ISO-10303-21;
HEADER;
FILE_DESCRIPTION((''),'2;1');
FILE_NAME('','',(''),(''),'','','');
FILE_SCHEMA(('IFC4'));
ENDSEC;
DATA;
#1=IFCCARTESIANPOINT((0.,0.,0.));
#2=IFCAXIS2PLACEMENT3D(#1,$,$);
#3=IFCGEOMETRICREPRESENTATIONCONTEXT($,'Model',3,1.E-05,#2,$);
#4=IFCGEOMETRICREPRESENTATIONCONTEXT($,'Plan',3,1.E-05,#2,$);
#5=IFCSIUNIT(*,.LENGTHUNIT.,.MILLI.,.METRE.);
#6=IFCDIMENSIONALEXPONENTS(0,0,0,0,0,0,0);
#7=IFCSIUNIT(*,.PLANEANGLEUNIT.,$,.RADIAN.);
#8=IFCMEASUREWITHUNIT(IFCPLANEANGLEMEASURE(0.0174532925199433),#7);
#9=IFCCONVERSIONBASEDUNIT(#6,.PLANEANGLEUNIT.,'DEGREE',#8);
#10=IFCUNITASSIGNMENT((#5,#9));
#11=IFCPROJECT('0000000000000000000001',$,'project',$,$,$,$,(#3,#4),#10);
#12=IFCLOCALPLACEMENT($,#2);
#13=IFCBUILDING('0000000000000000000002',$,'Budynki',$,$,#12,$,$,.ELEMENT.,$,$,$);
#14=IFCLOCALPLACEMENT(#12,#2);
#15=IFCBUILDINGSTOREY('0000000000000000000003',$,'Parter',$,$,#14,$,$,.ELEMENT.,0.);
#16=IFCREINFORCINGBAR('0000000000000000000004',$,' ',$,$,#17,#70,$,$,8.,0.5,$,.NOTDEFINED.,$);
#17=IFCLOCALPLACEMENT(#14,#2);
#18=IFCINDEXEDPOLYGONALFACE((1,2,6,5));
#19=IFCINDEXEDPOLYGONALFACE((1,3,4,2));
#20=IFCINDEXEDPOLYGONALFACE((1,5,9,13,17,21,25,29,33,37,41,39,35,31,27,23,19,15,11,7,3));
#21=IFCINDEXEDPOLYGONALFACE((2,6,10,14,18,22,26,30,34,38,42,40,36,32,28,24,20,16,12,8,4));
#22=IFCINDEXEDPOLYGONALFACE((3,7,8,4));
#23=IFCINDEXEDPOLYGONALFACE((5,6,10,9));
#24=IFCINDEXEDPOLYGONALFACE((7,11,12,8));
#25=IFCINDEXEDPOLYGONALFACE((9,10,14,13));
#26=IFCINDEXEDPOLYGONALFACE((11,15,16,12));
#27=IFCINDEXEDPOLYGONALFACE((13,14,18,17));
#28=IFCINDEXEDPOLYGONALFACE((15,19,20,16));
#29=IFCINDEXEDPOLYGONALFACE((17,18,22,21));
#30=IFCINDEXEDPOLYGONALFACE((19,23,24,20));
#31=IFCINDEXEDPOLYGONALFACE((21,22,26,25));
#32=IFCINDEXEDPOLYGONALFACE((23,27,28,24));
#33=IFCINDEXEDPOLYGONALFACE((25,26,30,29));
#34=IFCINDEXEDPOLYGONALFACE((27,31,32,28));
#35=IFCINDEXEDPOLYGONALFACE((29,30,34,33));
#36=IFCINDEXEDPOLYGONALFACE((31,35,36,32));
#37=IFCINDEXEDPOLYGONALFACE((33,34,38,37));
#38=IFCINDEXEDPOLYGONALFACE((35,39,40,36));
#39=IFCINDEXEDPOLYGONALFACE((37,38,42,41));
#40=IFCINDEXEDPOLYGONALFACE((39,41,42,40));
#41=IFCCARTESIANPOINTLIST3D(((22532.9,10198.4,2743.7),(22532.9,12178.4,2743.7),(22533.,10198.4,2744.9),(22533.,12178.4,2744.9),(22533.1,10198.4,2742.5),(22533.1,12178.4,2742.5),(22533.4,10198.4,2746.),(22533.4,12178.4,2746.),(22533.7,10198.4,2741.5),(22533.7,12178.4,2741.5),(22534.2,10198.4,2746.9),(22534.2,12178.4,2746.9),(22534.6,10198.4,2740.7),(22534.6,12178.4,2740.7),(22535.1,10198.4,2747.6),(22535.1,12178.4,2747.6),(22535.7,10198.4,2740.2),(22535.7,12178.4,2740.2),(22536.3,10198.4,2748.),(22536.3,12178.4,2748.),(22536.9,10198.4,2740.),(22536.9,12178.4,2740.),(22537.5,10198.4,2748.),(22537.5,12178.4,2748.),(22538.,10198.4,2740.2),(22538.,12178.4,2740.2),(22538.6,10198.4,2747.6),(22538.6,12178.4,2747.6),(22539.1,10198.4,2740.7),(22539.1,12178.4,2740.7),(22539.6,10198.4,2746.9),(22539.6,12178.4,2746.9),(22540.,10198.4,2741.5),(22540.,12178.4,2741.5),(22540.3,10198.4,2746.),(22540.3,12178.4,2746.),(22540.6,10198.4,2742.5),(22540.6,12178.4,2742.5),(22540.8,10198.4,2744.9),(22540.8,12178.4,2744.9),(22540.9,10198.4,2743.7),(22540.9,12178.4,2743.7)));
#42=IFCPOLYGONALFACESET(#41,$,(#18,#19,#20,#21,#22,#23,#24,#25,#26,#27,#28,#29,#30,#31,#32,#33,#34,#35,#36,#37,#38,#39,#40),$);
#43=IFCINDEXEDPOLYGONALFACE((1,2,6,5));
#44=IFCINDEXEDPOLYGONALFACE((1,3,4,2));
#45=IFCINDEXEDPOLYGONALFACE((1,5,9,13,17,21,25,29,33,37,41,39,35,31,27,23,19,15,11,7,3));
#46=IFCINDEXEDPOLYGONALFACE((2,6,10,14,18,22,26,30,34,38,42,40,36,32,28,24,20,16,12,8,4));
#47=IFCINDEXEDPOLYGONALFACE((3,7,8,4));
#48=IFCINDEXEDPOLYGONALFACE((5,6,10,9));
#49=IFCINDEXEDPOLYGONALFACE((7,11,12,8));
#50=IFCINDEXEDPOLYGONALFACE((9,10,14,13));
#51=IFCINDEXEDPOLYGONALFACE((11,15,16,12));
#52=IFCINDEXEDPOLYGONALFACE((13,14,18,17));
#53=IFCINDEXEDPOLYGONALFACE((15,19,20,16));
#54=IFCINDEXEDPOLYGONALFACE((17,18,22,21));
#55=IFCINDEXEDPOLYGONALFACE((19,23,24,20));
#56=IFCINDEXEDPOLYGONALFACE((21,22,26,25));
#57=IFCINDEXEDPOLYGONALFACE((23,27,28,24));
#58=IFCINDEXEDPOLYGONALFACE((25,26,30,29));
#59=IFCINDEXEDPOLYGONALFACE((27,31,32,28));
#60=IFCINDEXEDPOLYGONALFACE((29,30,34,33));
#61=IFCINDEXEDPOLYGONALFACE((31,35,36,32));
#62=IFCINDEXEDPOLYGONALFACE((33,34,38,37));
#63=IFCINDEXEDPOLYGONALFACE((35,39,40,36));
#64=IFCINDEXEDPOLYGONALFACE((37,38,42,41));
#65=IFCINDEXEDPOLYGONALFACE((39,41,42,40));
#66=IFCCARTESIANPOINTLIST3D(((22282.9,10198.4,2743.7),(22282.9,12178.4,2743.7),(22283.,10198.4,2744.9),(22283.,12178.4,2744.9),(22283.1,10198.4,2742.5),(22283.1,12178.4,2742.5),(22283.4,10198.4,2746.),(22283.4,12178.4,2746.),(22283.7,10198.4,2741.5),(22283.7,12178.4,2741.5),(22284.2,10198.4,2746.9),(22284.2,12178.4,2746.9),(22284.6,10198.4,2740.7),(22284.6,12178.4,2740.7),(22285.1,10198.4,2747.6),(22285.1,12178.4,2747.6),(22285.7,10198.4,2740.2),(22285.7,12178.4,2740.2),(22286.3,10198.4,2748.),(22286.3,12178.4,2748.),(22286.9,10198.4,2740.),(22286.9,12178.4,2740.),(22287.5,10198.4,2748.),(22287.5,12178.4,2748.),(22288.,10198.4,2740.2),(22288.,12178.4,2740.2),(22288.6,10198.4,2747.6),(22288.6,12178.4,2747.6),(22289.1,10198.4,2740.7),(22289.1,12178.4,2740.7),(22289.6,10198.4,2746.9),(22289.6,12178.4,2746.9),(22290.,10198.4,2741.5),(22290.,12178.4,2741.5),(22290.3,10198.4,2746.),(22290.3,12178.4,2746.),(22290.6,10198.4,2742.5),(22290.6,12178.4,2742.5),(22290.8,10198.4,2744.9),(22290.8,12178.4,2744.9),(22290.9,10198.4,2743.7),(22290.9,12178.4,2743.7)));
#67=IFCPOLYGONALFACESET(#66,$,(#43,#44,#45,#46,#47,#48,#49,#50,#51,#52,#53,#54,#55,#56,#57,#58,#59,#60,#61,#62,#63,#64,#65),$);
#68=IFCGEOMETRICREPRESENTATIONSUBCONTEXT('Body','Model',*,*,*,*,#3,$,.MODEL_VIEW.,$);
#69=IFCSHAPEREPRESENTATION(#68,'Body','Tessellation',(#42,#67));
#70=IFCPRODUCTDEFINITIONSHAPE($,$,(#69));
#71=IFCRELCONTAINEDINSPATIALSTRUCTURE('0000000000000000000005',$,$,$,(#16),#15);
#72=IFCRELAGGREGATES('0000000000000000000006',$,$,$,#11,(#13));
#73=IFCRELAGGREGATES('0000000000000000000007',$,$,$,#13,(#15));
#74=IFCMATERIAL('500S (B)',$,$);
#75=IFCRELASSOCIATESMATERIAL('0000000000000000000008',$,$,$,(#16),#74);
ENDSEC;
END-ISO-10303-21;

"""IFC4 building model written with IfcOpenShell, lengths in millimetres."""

from ifc_helpers import new_model, entity, si_unit, converted_unit, frame, origin, place, context, subcontext, project, spatial, material, element, save


model = new_model("IFC4")

# Units and contexts
model_context = context("Model", 3, precision=1e-05, world=origin())
plan_context = context("Plan", 3, precision=1e-05, world=origin())
body_context = subcontext(model_context, "Body", "Model", "MODEL_VIEW")
ifc_project = project(units=[si_unit("LENGTHUNIT", "METRE", prefix="MILLI"), converted_unit("PLANEANGLEUNIT", "DEGREE", entity("IfcPlaneAngleMeasure", 0.0174532925199433), si_unit("PLANEANGLEUNIT", "RADIAN"), dimensions=[0, 0, 0, 0, 0, 0, 0])], contexts=[model_context, plan_context])

# Building, storey
building_placement = place(None, origin())
building = spatial("IfcBuilding", under=ifc_project, at=building_placement, Name="Budynki", CompositionType="ELEMENT")
storey_placement = place(building_placement, origin())
storey = spatial("IfcBuildingStorey", under=building, at=storey_placement, Name="Parter", CompositionType="ELEMENT", Elevation=0.0)

# Reinforcing bar
ifc_material_1 = material(Name="500S (B)")
reinforcing_bar_1_placement = place(storey_placement, frame((22536.9, 12178.4, 2744.0)))
element("IfcReinforcingBar", 1, at=reinforcing_bar_1_placement, inside=storey, material=ifc_material_1, Name=" ", CrossSectionArea=0.5, NominalDiameter=8.0, PredefinedType="NOTDEFINED", context=body_context, shape_type="AdvancedSweptSolid", body=[
    entity("IfcSweptDiskSolid", entity("IfcPolyline", [entity("IfcCartesianPoint", [0.0, 0.0, 0.0]), entity("IfcCartesianPoint", [0.0, -1980.0, 0.0])]), 4.0, None, 0.0, 1.0),
    entity("IfcSweptDiskSolid", entity("IfcPolyline", [entity("IfcCartesianPoint", [-250.0, 0.0, 0.0]), entity("IfcCartesianPoint", [-250.0, -1980.0, 0.0])]), 4.0, None, 0.0, 1.0),
])

save(model, "model.ifc")
